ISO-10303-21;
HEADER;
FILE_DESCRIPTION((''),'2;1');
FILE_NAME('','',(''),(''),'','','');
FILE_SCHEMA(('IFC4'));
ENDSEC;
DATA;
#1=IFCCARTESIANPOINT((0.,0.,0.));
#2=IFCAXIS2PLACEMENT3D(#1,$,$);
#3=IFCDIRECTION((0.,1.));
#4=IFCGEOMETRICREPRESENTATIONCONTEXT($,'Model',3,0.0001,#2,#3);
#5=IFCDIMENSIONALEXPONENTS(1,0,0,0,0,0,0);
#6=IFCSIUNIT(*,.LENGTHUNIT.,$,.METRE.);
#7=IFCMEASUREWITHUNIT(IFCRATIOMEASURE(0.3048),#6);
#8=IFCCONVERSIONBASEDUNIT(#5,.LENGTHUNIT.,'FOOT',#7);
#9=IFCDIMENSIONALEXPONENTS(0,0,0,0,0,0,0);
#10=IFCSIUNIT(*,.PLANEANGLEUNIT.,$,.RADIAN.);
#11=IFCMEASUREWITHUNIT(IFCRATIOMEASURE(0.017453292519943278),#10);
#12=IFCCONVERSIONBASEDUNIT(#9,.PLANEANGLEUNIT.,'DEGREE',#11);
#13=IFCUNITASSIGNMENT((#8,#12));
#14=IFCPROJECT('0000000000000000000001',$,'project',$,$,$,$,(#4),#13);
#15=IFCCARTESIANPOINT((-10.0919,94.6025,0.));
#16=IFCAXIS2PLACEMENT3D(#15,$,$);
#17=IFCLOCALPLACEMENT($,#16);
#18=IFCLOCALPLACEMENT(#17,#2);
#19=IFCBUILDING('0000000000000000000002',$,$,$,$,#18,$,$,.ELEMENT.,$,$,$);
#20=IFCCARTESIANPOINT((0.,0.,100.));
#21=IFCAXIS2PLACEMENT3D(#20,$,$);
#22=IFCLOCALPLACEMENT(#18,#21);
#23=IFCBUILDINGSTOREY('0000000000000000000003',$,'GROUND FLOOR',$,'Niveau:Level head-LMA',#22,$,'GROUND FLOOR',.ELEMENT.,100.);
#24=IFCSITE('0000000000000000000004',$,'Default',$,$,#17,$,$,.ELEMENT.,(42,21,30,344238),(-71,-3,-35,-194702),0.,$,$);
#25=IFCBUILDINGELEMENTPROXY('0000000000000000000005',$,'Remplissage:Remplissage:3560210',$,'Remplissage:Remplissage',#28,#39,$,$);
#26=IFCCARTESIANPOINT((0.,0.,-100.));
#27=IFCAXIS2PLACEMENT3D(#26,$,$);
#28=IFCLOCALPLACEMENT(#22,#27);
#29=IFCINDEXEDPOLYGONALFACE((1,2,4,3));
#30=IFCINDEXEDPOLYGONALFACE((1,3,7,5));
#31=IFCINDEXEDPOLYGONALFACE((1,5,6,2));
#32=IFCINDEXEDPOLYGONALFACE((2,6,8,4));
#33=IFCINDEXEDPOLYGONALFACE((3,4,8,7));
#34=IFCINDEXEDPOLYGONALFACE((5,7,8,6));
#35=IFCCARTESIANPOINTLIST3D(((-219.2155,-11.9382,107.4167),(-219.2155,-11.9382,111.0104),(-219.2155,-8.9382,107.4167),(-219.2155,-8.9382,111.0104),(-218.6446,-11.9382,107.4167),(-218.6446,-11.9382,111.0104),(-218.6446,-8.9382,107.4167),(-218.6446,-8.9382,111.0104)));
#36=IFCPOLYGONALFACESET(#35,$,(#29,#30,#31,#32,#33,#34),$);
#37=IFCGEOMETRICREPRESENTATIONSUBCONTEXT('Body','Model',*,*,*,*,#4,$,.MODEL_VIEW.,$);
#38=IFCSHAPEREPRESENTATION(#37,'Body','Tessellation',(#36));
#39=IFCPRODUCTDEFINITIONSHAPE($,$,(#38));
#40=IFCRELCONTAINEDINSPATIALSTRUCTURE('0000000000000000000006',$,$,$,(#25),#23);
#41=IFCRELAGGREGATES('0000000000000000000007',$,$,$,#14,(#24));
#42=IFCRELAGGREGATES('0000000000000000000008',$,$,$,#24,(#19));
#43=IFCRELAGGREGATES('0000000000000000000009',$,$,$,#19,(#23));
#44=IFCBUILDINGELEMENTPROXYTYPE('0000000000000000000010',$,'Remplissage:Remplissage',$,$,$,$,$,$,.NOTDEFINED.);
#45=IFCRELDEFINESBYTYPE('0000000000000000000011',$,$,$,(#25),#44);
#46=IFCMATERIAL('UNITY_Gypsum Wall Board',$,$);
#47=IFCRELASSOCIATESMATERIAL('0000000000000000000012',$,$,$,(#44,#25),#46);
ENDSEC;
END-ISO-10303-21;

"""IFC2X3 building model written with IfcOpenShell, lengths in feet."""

from ifc_helpers import new_model, entity, si_unit, converted_unit, direction, frame, origin, origin_2d_with_axis, place, context, subcontext, project, spatial, rectangle, extrude, source, transform, mapped, material, type_object, type_shapes, element, save


model = new_model("IFC2X3")

# Units and contexts
model_context = context("Model", 3, precision=0.0001, world=origin(), true_north=direction((0.0, 1.0)))
body_context = subcontext(model_context, "Body", "Model", "MODEL_VIEW")
ifc_project = project(units=[converted_unit("LENGTHUNIT", "FOOT", entity("IfcRatioMeasure", 0.3048), si_unit("LENGTHUNIT", "METRE"), dimensions=[1, 0, 0, 0, 0, 0, 0]), converted_unit("PLANEANGLEUNIT", "DEGREE", entity("IfcRatioMeasure", 0.017453292519943278), si_unit("PLANEANGLEUNIT", "RADIAN"), dimensions=[0, 0, 0, 0, 0, 0, 0])], contexts=[model_context])

# Site, building, storey
site_placement = place(None, frame((-10.0919, 94.6025, 0.0)))
site = spatial("IfcSite", under=ifc_project, at=site_placement, Name="Default", CompositionType="ELEMENT", RefLatitude=(42, 21, 30, 344238), RefLongitude=(-71, -3, -35, -194702), RefElevation=0.0)
building_placement = place(site_placement, origin())
building = spatial("IfcBuilding", under=site, at=building_placement, CompositionType="ELEMENT")
storey_placement = place(building_placement, frame((0.0, 0.0, 100.0)))
storey = spatial("IfcBuildingStorey", under=building, at=storey_placement, Name="GROUND FLOOR", ObjectType="Niveau:Level head-LMA", LongName="GROUND FLOOR", CompositionType="ELEMENT", Elevation=100.0)

# Shared definitions
ifc_material_1 = material(Name="UNITY_Gypsum Wall Board")

# Building element proxy
building_element_proxy_type_1 = type_object("IfcBuildingElementProxyType", Name="Remplissage:Remplissage", PredefinedType="NOTDEFINED", material=ifc_material_1)
shared_shape_1 = source(origin(), body_context, "Body", "SweptSolid", [
    extrude(rectangle(XDim=0.5709, YDim=3.0, at=origin_2d_with_axis()), frame((-218.9301, -10.4382, 107.4167), z_axis=(0.0, 0.0, 1.0), x_axis=(-1.0, 0.0, 0.0)), (0.0, 0.0, 1.0), 3.5937),
])
type_shapes(building_element_proxy_type_1, [shared_shape_1])
proxy_1_placement = place(storey_placement, frame((0.0, 0.0, -100.0)))
element("IfcBuildingElementProxy", 1, at=proxy_1_placement, inside=storey, type_object=building_element_proxy_type_1, material=ifc_material_1, Name="Remplissage:Remplissage:3560210", ObjectType="Remplissage:Remplissage", context=body_context, shape_type="MappedRepresentation", body=[
    mapped(shared_shape_1, transform((0.0, 0.0, 0.0), scale=1.0)),
])

save(model, "model.ifc")
